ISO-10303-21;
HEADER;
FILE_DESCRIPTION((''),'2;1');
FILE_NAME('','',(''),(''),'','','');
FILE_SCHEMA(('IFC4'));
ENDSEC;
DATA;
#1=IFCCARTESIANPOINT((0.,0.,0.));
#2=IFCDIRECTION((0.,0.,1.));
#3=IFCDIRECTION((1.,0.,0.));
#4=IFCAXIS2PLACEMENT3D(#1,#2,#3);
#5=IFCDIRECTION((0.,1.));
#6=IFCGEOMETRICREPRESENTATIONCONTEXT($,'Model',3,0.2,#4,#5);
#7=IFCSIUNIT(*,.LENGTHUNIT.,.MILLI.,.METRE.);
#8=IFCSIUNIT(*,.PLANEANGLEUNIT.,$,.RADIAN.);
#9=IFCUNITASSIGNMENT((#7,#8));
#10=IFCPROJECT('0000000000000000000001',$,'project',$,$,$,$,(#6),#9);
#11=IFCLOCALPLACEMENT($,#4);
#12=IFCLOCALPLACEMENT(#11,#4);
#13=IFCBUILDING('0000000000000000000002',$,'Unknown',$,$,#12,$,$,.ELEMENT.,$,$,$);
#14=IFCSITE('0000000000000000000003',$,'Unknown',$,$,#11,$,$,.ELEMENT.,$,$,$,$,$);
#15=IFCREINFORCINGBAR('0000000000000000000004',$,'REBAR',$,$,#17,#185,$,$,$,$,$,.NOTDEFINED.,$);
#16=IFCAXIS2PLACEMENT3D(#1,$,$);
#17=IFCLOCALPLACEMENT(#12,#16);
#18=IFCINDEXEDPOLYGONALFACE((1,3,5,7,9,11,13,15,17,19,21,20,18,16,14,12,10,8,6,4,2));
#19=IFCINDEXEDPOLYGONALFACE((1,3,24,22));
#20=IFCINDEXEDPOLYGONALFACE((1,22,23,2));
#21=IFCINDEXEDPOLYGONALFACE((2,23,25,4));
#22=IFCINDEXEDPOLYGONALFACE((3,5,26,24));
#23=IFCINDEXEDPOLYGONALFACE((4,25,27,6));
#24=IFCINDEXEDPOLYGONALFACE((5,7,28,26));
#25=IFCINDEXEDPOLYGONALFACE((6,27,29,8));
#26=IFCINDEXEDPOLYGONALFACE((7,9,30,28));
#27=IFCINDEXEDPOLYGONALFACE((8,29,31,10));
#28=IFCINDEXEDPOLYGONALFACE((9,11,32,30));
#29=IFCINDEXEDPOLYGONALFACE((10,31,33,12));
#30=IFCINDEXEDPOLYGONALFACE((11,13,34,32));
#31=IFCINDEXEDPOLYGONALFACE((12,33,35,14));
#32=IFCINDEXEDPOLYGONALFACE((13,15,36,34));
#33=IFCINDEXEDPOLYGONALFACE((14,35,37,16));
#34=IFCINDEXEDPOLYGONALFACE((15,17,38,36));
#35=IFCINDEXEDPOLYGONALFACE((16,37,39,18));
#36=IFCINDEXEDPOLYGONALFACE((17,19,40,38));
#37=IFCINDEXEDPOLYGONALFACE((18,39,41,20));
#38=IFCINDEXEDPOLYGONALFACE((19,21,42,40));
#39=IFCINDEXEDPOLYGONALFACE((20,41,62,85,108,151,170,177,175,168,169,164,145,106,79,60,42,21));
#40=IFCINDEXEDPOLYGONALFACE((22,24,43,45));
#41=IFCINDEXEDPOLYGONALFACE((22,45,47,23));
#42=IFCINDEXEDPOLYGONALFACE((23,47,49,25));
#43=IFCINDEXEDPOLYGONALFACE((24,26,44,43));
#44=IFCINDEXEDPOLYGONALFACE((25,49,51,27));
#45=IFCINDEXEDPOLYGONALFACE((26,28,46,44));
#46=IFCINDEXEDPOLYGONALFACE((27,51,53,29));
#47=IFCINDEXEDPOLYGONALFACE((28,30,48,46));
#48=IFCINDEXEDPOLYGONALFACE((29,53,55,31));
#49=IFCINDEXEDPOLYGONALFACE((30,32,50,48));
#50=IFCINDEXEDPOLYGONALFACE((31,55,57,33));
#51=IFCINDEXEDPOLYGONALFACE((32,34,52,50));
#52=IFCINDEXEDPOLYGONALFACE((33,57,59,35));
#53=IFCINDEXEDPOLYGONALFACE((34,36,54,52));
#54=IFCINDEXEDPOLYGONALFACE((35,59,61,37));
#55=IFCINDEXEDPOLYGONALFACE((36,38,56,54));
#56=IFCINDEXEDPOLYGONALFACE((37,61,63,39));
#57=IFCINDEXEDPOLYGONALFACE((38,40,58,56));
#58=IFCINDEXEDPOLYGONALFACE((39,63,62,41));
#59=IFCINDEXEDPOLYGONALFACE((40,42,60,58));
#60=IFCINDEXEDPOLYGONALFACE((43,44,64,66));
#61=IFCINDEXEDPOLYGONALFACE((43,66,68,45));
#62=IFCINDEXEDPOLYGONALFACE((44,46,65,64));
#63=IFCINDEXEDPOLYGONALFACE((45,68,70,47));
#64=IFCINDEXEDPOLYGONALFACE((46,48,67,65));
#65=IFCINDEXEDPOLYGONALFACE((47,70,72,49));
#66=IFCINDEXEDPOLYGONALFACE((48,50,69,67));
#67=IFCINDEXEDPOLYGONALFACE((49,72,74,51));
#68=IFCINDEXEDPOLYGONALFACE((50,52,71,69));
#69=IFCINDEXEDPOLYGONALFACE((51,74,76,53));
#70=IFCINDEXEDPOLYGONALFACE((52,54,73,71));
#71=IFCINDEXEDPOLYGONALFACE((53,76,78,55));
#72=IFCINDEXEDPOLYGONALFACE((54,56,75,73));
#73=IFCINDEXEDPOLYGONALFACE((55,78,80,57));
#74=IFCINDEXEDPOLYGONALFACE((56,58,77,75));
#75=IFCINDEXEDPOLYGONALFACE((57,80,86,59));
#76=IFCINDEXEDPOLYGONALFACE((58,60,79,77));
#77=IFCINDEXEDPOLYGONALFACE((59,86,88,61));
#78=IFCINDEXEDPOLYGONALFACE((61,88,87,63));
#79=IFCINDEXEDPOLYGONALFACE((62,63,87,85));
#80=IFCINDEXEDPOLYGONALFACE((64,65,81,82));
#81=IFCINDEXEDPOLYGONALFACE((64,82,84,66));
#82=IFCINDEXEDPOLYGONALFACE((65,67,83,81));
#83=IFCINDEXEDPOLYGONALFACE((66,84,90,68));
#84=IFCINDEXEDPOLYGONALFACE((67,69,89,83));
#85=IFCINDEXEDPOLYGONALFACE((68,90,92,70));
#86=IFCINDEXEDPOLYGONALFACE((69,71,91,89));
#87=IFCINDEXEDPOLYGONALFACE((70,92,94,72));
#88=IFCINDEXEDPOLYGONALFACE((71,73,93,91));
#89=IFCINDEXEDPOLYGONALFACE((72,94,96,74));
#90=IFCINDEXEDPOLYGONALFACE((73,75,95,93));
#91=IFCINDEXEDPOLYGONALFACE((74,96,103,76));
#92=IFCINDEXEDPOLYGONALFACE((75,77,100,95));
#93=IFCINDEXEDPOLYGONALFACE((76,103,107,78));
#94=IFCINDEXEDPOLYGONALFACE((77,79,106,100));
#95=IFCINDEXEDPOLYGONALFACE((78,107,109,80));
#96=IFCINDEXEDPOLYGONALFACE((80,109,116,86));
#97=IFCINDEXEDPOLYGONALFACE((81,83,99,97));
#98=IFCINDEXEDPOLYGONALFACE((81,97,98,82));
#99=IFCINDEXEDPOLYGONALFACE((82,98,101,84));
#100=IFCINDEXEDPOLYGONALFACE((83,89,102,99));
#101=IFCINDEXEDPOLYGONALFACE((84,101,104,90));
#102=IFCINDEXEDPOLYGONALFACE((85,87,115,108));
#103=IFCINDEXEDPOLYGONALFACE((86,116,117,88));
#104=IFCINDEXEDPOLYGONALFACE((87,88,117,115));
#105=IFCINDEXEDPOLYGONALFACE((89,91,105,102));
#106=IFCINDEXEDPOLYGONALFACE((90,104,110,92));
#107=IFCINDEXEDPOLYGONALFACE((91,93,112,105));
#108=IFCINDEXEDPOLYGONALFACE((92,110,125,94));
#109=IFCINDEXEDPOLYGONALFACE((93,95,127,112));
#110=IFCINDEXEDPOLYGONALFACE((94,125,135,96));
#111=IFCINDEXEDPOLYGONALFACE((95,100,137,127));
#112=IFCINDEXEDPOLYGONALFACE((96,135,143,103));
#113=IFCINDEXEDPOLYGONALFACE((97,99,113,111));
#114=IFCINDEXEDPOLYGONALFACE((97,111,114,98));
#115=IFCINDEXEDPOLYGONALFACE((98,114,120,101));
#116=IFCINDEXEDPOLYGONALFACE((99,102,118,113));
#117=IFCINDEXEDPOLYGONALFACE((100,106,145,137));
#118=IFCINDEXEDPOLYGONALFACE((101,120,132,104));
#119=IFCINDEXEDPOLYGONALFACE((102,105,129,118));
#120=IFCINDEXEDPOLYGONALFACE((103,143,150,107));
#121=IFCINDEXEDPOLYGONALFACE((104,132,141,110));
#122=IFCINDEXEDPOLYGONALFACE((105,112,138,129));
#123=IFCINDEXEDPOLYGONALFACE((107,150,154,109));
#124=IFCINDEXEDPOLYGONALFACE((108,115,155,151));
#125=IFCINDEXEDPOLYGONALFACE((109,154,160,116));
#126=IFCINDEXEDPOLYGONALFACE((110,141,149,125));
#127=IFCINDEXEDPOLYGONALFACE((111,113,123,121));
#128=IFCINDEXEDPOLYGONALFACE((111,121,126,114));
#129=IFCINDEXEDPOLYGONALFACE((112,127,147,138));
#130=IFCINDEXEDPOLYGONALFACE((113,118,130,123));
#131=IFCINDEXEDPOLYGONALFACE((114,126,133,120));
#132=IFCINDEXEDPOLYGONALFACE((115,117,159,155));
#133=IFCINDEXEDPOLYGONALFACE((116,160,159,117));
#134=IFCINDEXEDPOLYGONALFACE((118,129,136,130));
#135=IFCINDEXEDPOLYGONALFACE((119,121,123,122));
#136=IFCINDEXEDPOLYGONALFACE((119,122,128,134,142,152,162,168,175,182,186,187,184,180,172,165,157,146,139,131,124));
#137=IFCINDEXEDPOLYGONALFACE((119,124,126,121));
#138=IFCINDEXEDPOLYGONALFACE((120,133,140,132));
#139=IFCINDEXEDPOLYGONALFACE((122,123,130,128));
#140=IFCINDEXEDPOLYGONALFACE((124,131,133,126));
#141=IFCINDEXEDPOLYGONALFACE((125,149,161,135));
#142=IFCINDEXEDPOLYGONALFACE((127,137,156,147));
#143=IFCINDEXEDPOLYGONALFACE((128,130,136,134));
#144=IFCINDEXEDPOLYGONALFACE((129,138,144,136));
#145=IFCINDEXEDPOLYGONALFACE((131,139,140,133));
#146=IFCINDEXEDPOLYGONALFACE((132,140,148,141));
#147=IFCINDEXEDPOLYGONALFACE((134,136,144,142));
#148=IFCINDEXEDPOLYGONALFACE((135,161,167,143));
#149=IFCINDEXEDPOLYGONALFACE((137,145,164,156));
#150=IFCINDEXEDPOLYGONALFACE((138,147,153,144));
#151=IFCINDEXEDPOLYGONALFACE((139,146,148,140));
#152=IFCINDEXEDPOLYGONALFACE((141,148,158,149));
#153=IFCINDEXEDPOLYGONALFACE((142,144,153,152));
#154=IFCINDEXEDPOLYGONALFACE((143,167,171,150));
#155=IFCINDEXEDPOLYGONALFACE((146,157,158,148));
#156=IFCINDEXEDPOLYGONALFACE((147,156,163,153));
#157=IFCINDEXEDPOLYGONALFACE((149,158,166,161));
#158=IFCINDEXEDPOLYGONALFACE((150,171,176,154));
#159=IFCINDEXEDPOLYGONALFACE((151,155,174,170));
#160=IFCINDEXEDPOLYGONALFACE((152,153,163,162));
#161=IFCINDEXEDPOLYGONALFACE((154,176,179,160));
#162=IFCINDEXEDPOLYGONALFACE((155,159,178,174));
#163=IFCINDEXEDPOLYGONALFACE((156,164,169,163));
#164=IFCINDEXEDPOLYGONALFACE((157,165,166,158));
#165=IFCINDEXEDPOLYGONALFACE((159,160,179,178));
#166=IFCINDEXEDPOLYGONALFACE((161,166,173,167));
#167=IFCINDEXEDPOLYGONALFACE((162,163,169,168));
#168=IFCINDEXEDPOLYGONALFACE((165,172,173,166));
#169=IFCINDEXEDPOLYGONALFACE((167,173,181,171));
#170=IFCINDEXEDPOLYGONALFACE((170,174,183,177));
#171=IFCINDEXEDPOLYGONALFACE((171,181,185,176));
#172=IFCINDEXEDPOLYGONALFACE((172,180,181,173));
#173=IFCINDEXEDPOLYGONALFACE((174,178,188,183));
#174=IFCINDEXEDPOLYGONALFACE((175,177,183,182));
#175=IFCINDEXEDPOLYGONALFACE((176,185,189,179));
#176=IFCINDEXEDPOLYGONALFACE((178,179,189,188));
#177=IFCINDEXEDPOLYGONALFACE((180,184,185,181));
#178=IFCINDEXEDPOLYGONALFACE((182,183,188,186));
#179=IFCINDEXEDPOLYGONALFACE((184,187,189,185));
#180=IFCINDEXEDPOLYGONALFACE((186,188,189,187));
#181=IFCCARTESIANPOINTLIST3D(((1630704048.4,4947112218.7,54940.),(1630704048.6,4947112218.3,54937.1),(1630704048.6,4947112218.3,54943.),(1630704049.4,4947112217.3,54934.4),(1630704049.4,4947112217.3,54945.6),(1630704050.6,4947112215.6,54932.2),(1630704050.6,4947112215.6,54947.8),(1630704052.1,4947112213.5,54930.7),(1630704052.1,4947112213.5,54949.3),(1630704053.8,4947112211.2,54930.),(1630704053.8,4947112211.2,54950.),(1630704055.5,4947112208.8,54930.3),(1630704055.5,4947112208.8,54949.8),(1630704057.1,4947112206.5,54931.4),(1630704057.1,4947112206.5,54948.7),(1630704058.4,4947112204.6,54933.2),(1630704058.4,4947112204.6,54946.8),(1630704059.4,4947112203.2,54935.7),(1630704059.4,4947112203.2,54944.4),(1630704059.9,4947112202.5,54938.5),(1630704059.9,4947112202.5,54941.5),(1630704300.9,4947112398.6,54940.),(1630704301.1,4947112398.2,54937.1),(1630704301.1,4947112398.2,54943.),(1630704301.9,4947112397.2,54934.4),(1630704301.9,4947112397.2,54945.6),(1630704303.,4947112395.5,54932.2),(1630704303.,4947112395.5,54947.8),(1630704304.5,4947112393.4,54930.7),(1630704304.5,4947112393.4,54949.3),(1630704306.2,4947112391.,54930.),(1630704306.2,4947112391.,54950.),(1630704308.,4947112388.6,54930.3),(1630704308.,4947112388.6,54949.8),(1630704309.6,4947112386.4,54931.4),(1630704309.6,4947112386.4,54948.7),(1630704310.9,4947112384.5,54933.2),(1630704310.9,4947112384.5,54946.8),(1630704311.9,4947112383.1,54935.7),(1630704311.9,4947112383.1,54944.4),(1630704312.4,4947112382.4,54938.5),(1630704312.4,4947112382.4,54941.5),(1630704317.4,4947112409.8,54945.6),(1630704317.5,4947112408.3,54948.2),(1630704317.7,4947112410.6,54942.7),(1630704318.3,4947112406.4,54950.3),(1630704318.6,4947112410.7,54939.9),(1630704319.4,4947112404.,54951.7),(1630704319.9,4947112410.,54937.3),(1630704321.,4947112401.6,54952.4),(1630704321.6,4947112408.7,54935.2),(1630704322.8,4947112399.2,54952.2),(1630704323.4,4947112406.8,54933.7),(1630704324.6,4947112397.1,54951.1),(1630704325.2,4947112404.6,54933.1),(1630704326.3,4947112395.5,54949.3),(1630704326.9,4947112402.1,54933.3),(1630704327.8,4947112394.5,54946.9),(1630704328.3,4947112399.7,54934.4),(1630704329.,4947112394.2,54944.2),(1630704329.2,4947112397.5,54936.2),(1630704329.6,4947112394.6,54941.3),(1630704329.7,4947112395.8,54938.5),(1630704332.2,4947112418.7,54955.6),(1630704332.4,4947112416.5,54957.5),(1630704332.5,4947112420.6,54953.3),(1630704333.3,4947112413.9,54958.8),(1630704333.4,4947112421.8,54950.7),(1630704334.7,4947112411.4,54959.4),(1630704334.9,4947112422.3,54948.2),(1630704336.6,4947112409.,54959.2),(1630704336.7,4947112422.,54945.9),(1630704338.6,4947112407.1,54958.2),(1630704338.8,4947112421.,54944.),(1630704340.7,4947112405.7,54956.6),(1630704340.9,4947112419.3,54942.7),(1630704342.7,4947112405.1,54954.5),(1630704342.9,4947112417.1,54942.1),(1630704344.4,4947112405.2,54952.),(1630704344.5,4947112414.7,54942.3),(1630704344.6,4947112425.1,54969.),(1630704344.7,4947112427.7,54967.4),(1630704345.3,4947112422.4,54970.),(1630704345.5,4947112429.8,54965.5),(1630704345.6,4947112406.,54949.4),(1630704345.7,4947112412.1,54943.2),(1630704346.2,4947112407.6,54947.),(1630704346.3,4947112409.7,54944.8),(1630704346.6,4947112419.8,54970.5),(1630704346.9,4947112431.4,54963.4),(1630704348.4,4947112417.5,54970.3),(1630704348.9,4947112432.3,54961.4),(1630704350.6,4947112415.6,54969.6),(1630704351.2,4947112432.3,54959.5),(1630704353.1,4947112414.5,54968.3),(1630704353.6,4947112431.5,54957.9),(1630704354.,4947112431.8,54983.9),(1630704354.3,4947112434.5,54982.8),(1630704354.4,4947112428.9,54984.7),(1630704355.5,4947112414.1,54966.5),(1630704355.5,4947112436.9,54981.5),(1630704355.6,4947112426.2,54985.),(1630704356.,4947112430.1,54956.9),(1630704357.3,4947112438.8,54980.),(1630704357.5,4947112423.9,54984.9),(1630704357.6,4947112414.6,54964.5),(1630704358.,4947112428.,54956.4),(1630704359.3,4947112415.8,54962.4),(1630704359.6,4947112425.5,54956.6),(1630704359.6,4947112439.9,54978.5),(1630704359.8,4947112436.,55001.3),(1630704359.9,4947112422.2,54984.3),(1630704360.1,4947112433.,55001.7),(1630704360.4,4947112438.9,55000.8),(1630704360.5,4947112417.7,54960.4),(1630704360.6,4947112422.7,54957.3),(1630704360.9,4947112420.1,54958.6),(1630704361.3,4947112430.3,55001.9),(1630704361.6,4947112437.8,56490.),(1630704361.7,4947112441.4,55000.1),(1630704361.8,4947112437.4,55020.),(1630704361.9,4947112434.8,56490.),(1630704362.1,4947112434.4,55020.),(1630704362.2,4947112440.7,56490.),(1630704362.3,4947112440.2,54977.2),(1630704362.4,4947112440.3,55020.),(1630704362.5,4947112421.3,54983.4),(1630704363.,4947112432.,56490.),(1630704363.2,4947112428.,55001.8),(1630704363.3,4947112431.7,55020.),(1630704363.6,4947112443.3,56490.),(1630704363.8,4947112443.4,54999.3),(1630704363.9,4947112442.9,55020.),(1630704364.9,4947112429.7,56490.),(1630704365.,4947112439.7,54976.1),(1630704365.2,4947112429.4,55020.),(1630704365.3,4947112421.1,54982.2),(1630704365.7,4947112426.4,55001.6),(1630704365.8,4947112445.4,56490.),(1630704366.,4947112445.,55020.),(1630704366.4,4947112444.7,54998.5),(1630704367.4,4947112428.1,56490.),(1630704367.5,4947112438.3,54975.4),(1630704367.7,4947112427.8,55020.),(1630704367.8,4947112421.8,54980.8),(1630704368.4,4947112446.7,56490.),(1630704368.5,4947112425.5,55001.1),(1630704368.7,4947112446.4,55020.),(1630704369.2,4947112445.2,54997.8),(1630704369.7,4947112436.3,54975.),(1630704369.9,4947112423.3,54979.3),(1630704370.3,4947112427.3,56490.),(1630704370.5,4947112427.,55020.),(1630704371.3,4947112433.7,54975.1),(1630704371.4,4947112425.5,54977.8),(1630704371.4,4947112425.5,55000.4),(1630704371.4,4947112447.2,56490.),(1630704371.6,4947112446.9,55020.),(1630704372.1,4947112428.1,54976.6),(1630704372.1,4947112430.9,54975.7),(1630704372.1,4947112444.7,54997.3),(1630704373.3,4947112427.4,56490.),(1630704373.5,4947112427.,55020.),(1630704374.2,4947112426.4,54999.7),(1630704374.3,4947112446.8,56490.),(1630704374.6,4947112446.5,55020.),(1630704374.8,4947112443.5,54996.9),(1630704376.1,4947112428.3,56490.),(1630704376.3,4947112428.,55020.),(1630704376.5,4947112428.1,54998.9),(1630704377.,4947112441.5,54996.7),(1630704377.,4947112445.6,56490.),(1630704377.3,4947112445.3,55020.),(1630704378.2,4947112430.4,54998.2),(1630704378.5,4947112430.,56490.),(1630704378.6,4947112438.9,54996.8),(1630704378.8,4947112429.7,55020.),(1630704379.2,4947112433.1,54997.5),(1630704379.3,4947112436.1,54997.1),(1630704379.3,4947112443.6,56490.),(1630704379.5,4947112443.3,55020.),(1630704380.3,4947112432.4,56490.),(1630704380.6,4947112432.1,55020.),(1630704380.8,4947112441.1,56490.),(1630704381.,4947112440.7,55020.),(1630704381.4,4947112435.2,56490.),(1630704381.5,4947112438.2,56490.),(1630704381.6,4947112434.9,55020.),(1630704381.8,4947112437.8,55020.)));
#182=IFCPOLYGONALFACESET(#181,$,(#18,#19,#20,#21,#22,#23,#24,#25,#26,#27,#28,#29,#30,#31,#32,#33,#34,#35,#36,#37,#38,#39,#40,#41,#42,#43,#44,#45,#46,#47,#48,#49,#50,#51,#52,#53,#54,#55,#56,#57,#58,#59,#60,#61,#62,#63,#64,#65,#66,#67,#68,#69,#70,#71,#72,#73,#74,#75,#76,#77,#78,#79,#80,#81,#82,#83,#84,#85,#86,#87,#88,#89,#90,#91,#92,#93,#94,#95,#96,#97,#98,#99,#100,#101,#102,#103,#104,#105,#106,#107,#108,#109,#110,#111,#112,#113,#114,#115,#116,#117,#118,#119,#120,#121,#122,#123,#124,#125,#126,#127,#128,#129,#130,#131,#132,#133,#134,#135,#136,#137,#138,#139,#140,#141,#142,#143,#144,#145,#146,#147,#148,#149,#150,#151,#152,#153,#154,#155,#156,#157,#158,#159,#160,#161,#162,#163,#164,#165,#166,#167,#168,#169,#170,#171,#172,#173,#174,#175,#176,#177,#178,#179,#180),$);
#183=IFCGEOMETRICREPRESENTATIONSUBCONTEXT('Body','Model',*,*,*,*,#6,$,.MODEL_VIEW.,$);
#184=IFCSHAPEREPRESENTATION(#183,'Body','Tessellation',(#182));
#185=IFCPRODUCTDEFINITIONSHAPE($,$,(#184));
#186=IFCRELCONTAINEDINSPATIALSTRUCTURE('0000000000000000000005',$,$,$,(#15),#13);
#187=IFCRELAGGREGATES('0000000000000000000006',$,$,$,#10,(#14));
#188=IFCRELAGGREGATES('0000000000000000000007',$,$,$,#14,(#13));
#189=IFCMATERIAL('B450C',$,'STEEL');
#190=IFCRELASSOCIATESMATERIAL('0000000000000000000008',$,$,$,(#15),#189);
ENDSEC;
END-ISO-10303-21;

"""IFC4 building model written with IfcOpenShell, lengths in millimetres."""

from ifc_helpers import new_model, entity, si_unit, direction, frame, origin_with_axes, place, context, subcontext, project, spatial, material, element, save


model = new_model("IFC4")

# Units and contexts
model_context = context("Model", 3, precision=0.2, world=origin_with_axes(), true_north=direction((0.0, 1.0)))
body_context = subcontext(model_context, "Body", "Model", "MODEL_VIEW")
ifc_project = project(units=[si_unit("LENGTHUNIT", "METRE", prefix="MILLI"), si_unit("PLANEANGLEUNIT", "RADIAN")], contexts=[model_context])

# Site, building
site_placement = place(None, origin_with_axes())
site = spatial("IfcSite", under=ifc_project, at=site_placement, Name="Unknown", CompositionType="ELEMENT")
building_placement = place(site_placement, origin_with_axes())
building = spatial("IfcBuilding", under=site, at=building_placement, Name="Unknown", CompositionType="ELEMENT")

# Reinforcing bar
ifc_material = material(Name="B450C", Category="STEEL")
reinforcing_bar_1_placement = place(building_placement, frame((1630704383.5, 4947112506.6, 54890.0), z_axis=(0.580234, -0.81445, 0.0), x_axis=(0.0, 0.0, 1.0)))
element("IfcReinforcingBar", 1, at=reinforcing_bar_1_placement, inside=building, material=ifc_material, Name="REBAR", PredefinedType="NOTDEFINED", context=body_context, shape_type="AdvancedSweptSolid", body=[
    entity("IfcSweptDiskSolid", entity("IfcIndexedPolyCurve", entity("IfcCartesianPointList3D", [[50.0, 440.0, 50.0], [50.0, 130.0, 50.0], [73.4, 73.4, 50.0], [130.0, 50.0, 50.0], [1600.0, 50.0, 49.5]]), [entity("IfcLineIndex", [1, 2]), entity("IfcArcIndex", [2, 3, 4]), entity("IfcLineIndex", [4, 5])]), 10.0),
])

save(model, "model.ifc")
